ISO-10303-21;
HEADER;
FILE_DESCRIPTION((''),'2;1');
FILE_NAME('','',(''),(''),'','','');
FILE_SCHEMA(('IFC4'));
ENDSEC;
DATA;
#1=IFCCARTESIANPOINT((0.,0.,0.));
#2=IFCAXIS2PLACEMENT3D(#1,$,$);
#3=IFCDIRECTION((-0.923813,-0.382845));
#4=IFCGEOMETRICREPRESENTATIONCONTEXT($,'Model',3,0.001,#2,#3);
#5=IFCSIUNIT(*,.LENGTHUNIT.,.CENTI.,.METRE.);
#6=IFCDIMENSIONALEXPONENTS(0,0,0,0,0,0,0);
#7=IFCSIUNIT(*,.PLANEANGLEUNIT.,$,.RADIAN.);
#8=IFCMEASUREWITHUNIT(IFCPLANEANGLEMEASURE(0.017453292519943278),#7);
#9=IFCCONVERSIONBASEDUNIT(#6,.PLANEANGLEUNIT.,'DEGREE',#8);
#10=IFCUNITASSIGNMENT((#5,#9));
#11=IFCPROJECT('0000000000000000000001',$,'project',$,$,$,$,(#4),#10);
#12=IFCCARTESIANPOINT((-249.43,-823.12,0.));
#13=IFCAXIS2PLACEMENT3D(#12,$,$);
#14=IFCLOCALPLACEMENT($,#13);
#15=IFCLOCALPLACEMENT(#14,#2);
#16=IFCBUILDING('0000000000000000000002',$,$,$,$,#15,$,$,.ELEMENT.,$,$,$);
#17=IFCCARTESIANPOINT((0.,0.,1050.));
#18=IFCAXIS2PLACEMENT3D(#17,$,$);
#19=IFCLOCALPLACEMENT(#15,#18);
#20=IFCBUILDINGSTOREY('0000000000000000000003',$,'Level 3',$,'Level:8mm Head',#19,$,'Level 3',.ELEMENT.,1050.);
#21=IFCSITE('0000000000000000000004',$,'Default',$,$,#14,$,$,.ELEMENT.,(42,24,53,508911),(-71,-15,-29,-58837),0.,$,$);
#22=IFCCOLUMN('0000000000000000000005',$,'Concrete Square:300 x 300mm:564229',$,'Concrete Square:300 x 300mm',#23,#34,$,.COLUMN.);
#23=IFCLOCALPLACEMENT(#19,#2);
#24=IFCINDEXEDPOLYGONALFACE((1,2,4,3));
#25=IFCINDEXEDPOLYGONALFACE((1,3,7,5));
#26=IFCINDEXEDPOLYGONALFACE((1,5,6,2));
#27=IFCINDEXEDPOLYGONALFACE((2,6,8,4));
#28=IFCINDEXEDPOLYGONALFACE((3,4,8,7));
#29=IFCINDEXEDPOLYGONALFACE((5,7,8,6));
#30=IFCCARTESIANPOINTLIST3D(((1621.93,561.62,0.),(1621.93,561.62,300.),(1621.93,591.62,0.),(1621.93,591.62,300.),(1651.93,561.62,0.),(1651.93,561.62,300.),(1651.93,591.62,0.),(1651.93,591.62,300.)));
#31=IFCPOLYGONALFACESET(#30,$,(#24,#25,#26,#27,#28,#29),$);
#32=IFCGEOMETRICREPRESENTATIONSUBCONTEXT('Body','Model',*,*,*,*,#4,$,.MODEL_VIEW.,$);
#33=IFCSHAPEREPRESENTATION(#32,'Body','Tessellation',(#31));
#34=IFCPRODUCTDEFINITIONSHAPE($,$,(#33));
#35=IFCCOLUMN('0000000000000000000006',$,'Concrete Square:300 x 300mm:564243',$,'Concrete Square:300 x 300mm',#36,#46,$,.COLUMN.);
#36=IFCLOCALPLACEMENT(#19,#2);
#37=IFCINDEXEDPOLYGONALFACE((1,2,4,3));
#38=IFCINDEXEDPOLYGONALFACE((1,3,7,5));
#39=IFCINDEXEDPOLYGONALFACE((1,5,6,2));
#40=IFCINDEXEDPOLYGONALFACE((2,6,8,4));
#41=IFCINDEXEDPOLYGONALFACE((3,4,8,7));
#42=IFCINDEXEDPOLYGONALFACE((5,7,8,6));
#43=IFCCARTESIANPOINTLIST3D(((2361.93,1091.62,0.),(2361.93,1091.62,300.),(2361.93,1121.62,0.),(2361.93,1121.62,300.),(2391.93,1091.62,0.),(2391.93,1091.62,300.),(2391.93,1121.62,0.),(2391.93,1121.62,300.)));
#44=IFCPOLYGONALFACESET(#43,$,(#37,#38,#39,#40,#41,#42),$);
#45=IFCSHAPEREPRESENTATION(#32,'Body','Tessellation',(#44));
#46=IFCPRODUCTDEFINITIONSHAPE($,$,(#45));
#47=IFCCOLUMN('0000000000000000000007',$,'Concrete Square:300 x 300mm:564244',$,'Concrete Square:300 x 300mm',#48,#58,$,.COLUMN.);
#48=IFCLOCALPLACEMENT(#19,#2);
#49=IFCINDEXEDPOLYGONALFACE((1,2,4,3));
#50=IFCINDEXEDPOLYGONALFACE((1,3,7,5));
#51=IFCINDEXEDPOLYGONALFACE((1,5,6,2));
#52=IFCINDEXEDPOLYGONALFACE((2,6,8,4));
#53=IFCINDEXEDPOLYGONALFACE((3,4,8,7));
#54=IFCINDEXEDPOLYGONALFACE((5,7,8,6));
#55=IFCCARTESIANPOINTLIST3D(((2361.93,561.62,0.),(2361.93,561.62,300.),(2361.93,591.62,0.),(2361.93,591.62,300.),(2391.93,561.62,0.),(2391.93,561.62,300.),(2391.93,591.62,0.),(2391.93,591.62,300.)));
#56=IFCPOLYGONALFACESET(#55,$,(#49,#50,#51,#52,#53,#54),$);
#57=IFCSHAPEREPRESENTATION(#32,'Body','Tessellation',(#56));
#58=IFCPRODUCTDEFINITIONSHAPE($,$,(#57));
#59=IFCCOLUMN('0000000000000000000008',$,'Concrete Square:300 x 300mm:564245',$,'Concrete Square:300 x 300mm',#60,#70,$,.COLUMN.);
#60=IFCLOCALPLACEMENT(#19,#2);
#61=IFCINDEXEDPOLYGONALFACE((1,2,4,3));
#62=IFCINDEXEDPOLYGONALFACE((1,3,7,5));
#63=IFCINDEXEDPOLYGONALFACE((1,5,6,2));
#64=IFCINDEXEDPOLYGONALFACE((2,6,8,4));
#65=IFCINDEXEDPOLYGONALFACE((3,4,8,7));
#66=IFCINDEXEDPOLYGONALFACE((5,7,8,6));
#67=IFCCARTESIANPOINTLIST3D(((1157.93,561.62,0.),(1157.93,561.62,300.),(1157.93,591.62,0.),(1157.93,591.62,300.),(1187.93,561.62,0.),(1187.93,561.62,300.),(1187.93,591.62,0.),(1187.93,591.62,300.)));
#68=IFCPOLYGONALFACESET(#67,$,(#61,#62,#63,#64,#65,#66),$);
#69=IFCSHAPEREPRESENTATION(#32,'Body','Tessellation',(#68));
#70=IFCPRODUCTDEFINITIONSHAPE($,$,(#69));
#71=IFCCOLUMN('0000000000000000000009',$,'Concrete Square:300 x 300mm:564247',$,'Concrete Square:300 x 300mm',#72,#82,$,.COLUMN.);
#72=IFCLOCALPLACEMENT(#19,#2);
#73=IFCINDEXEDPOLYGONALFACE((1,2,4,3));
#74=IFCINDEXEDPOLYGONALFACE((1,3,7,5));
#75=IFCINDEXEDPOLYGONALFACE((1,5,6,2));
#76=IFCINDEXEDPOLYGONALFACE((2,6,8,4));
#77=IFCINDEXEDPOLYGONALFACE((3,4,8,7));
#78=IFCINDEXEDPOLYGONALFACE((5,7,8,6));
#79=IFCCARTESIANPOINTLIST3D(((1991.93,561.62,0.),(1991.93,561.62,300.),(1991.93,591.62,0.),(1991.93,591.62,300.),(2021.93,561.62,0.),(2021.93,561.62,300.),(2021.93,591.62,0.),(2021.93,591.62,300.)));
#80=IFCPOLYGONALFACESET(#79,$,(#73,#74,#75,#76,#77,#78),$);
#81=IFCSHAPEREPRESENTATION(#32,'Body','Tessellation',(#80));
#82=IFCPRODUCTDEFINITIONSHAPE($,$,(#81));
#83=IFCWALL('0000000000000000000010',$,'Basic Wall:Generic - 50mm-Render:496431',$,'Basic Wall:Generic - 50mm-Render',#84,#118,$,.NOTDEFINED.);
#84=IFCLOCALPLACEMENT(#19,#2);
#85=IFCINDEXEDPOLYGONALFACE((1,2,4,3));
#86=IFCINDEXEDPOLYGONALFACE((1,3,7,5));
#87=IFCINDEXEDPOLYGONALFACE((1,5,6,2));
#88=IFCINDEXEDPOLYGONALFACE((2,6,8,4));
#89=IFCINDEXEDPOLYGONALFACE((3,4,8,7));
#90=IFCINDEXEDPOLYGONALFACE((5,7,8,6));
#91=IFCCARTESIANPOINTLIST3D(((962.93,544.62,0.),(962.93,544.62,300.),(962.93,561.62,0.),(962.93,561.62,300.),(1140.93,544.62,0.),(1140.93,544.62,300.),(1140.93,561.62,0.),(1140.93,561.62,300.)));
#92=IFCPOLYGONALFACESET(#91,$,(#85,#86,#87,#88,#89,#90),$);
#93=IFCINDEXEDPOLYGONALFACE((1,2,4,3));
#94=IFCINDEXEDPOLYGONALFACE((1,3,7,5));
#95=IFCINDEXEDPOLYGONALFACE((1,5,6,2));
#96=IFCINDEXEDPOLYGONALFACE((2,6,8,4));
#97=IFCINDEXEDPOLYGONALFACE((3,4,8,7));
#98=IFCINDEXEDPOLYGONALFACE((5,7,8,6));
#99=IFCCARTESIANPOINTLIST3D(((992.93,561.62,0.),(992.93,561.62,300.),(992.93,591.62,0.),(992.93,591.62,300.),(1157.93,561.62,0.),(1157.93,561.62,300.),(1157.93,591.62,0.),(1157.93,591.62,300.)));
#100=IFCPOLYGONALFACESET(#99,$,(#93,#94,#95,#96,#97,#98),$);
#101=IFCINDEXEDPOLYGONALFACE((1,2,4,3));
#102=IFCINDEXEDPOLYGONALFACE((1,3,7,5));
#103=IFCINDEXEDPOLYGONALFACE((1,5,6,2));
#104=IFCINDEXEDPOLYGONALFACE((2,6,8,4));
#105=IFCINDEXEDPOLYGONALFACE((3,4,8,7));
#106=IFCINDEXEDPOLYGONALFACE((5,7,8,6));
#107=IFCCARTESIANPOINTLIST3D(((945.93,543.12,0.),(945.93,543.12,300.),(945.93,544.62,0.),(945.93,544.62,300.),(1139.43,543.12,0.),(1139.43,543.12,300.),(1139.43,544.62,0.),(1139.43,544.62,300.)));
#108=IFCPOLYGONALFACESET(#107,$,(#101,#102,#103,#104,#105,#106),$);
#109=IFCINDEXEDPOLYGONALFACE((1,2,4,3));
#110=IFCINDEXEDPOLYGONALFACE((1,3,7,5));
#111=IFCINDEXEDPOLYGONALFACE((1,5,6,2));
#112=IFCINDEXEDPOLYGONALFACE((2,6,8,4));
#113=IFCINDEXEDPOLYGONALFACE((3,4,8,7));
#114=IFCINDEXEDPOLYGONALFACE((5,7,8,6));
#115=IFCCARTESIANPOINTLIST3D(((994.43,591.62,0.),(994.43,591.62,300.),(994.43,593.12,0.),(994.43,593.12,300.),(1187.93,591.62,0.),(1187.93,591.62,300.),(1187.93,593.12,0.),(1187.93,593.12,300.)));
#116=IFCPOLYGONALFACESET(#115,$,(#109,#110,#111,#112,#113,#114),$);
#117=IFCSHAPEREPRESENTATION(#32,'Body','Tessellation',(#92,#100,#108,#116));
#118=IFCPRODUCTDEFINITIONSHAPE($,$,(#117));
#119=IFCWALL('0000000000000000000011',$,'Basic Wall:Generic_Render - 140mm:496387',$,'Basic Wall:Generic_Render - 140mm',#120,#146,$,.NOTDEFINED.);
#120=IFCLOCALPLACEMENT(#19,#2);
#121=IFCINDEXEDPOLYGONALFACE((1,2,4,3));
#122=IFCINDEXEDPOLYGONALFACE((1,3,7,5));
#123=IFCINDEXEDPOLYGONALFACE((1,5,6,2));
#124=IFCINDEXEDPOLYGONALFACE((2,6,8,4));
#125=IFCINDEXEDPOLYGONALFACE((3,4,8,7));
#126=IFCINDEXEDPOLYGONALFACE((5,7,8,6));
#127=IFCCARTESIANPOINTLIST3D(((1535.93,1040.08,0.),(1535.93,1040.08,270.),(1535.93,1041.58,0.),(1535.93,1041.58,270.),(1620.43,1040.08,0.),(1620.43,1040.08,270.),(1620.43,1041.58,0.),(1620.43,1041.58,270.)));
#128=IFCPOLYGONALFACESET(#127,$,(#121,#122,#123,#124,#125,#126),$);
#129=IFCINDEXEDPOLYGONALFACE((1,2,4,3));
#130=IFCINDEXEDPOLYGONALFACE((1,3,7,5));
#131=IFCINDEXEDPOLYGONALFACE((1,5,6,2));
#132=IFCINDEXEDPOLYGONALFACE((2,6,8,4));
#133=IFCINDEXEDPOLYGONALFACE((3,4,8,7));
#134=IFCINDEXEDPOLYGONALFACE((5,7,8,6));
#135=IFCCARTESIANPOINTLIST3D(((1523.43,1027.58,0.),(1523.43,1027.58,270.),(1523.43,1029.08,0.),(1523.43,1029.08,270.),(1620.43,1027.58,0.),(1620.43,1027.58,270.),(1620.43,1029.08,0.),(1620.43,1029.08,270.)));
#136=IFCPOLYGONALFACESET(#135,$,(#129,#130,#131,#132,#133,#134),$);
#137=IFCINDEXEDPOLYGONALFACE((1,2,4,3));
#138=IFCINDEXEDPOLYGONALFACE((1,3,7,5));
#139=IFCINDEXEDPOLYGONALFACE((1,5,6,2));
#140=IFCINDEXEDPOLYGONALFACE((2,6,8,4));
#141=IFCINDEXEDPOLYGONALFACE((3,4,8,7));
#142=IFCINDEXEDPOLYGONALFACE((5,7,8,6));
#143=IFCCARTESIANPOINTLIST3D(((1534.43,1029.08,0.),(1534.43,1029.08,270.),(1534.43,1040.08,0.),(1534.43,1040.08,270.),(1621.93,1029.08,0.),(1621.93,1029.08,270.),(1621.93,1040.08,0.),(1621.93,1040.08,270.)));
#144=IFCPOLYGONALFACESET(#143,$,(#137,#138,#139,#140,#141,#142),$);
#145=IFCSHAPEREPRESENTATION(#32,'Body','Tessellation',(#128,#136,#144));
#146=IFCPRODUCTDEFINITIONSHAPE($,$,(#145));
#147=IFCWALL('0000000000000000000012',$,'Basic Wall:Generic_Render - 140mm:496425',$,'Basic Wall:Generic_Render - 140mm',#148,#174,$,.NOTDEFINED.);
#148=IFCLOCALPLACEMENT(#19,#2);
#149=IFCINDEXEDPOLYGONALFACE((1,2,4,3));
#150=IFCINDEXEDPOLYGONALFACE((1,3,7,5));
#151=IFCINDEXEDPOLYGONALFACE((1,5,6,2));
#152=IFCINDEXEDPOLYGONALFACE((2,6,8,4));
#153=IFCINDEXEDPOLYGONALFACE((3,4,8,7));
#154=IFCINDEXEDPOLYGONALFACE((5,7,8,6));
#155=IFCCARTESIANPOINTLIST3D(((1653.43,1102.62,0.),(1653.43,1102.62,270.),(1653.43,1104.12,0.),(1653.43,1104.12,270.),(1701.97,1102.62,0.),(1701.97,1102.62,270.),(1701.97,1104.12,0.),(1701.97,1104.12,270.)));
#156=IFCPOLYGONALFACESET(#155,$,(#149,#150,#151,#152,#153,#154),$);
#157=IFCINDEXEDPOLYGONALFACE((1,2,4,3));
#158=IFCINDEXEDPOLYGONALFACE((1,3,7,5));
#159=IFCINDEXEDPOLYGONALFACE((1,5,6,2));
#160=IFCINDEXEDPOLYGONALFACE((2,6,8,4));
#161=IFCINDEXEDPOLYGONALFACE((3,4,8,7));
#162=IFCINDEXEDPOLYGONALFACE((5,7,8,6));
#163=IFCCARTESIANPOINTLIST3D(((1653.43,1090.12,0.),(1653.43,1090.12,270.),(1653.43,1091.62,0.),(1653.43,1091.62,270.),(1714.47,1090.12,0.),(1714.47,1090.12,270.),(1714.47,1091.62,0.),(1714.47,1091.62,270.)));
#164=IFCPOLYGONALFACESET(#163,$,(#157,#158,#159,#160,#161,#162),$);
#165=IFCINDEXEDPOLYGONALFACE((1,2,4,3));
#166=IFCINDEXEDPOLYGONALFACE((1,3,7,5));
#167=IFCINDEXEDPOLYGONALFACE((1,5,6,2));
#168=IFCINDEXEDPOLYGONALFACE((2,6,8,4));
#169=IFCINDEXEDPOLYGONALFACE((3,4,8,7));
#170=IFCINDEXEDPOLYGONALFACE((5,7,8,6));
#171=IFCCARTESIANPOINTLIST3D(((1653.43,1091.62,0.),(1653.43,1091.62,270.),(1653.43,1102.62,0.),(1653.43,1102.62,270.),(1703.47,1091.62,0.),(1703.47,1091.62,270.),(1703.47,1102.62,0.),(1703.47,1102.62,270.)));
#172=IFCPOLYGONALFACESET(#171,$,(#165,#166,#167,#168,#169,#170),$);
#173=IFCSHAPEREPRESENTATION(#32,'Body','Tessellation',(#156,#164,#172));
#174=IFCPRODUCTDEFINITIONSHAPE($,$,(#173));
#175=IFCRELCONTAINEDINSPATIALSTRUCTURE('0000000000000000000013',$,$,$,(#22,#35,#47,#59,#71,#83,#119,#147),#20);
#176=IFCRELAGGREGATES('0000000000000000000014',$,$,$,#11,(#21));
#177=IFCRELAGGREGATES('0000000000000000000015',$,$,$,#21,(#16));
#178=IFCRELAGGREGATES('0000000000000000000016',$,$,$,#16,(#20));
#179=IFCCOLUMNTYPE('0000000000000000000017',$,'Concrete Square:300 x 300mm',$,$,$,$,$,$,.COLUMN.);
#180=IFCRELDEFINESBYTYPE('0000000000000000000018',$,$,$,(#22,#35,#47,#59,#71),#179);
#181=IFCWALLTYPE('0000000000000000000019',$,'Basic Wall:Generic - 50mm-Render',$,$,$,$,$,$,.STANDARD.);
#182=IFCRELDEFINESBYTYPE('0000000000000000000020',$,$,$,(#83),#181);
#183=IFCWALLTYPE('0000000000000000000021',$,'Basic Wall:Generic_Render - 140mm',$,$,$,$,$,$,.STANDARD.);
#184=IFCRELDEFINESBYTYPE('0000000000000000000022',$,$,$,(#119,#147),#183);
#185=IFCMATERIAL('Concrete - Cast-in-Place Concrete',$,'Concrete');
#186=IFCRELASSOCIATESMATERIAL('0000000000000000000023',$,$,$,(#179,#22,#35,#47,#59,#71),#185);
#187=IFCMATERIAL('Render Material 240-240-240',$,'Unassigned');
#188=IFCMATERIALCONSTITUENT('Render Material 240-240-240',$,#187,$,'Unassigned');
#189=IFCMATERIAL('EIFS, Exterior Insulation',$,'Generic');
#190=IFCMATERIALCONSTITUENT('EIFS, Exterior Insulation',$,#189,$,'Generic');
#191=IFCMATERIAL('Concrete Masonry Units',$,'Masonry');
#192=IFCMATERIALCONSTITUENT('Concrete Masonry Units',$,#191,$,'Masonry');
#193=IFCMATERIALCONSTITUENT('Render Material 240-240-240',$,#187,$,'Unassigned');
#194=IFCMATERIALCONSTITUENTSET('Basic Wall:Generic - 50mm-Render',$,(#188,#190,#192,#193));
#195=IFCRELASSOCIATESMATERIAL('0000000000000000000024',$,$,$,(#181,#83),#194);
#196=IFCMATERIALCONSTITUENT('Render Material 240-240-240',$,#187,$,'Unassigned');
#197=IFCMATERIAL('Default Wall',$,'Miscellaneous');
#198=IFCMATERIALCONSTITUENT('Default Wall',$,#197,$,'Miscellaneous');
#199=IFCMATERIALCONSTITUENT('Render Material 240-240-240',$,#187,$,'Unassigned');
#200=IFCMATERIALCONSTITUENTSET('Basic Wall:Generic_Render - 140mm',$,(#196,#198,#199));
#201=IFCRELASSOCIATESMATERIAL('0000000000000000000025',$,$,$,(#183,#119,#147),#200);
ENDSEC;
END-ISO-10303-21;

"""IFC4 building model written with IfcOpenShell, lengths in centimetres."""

from ifc_helpers import new_model, entity, si_unit, converted_unit, direction, frame, origin, place, context, subcontext, project, spatial, indexed_curve, outline, extrude, source, transform, mapped, material, constituent, constituent_set, type_object, type_shapes, element, save


model = new_model("IFC4")

# Units and contexts
model_context = context("Model", 3, precision=0.001, world=origin(), true_north=direction((-0.923813, -0.382845)))
body_context = subcontext(model_context, "Body", "Model", "MODEL_VIEW")
ifc_project = project(units=[si_unit("LENGTHUNIT", "METRE", prefix="CENTI"), converted_unit("PLANEANGLEUNIT", "DEGREE", entity("IfcPlaneAngleMeasure", 0.017453292519943278), si_unit("PLANEANGLEUNIT", "RADIAN"), dimensions=[0, 0, 0, 0, 0, 0, 0])], contexts=[model_context])

# Site, building, storey
site_placement = place(None, frame((-249.43, -823.12, 0.0)))
site = spatial("IfcSite", under=ifc_project, at=site_placement, Name="Default", CompositionType="ELEMENT", RefLatitude=(42, 24, 53, 508911), RefLongitude=(-71, -15, -29, -58837), RefElevation=0.0)
building_placement = place(site_placement, origin())
building = spatial("IfcBuilding", under=site, at=building_placement, CompositionType="ELEMENT")
storey_placement = place(building_placement, frame((0.0, 0.0, 1050.0)))
storey = spatial("IfcBuildingStorey", under=building, at=storey_placement, Name="Level 3", ObjectType="Level:8mm Head", LongName="Level 3", CompositionType="ELEMENT", Elevation=1050.0)

# Columns
ifc_material_1 = material(Name="Concrete - Cast-in-Place Concrete", Category="Concrete")
column_type = type_object("IfcColumnType", Name="Concrete Square:300 x 300mm", PredefinedType="COLUMN", material=ifc_material_1)
shared_shape_1 = source(origin(), body_context, "Body", "SweptSolid", [
    extrude(outline(indexed_curve([(-15.0, -15.0), (15.0, -15.0), (15.0, 15.0), (-15.0, 15.0), (-15.0, -15.0)], self_intersect=False)), frame((0.0, 0.0, 1050.0), z_axis=(0.0, 0.0, 1.0), x_axis=(-1.0, 0.0, 0.0)), (0.0, 0.0, 1.0), 300.0),
])
type_shapes(column_type, [shared_shape_1])
for number, where, name in (
    (1, (1636.93, 576.62, -1050.0), "Concrete Square:300 x 300mm:564229"),
    (2, (2376.93, 1106.62, -1050.0), "Concrete Square:300 x 300mm:564243"),
    (3, (2376.93, 576.62, -1050.0), "Concrete Square:300 x 300mm:564244"),
    (4, (1172.93, 576.62, -1050.0), "Concrete Square:300 x 300mm:564245"),
    (5, (2006.93, 576.62, -1050.0), "Concrete Square:300 x 300mm:564247"),
):
    element("IfcColumn", number, at=place(storey_placement, frame(where)), inside=storey, type_object=column_type, material=ifc_material_1, Name=name, ObjectType="Concrete Square:300 x 300mm", PredefinedType="COLUMN", context=body_context, shape_type="MappedRepresentation", body=[
        mapped(shared_shape_1, transform((0.0, 0.0, 0.0), scale=1.0)),
    ])

# Walls
ifc_material_2 = material(Name="Render Material 240-240-240", Category="Unassigned")
ifc_material_3 = material(Name="Default Wall", Category="Miscellaneous")
ifc_constituent_1 = constituent(ifc_material_2, Name="Render Material 240-240-240", Category="Unassigned")
ifc_material_4 = material(Name="EIFS, Exterior Insulation", Category="Generic")
ifc_constituent_2 = constituent(ifc_material_4, Name="EIFS, Exterior Insulation", Category="Generic")
ifc_material_5 = material(Name="Concrete Masonry Units", Category="Masonry")
ifc_constituent_3 = constituent(ifc_material_5, Name="Concrete Masonry Units", Category="Masonry")
ifc_constituent_4 = constituent(ifc_material_2, Name="Render Material 240-240-240", Category="Unassigned")
ifc_constituent_set_1 = constituent_set(constituents=[ifc_constituent_1, ifc_constituent_2, ifc_constituent_3, ifc_constituent_4], Name="Basic Wall:Generic - 50mm-Render")
wall_type_1 = type_object("IfcWallType", Name="Basic Wall:Generic - 50mm-Render", PredefinedType="STANDARD", material=ifc_constituent_set_1)
wall_1_placement = place(storey_placement, frame((1139.43, 568.12, 0.0), z_axis=(0.0, 0.0, 1.0), x_axis=(-1.0, 0.0, 0.0)))
element("IfcWall", 6, at=wall_1_placement, inside=storey, type_object=wall_type_1, material=ifc_constituent_set_1, Name="Basic Wall:Generic - 50mm-Render:496431", ObjectType="Basic Wall:Generic - 50mm-Render", PredefinedType="NOTDEFINED", context=body_context, shape_type="SweptSolid", body=[
    extrude(outline(indexed_curve([(-89.0, -8.5), (89.0, -8.5), (89.0, 8.5), (-89.0, 8.5), (-89.0, -8.5)], self_intersect=False)), frame((87.5, 15.0, 0.0)), (0.0, 0.0, 1.0), 300.0),
    extrude(outline(indexed_curve([(-82.5, -15.0), (82.5, -15.0), (82.5, 15.0), (-82.5, 15.0), (-82.5, -15.0)], self_intersect=False)), frame((64.0, -8.5, 0.0)), (0.0, 0.0, 1.0), 300.0),
    extrude(outline(indexed_curve([(-0.75, -96.75), (0.75, -96.75), (0.75, 96.75), (-0.75, 96.75), (-0.75, -96.75)], self_intersect=False)), frame((96.75, 24.25, 0.0), z_axis=(0.0, 0.0, 1.0), x_axis=(0.0, -1.0, 0.0)), (0.0, 0.0, 1.0), 300.0),
    extrude(outline(indexed_curve([(-0.75, -96.75), (0.75, -96.75), (0.75, 96.75), (-0.75, 96.75), (-0.75, -96.75)], self_intersect=False)), frame((48.25, -24.25, 0.0), z_axis=(0.0, 0.0, 1.0), x_axis=(0.0, 1.0, 0.0)), (0.0, 0.0, 1.0), 300.0),
])
ifc_constituent_5 = constituent(ifc_material_2, Name="Render Material 240-240-240", Category="Unassigned")
ifc_constituent_6 = constituent(ifc_material_3, Name="Default Wall", Category="Miscellaneous")
ifc_constituent_7 = constituent(ifc_material_2, Name="Render Material 240-240-240", Category="Unassigned")
ifc_constituent_set_2 = constituent_set(constituents=[ifc_constituent_5, ifc_constituent_6, ifc_constituent_7], Name="Basic Wall:Generic_Render - 140mm")
wall_type_2 = type_object("IfcWallType", Name="Basic Wall:Generic_Render - 140mm", PredefinedType="STANDARD", material=ifc_constituent_set_2)
wall_2_placement = place(storey_placement, frame((1535.93, 1034.58, 0.0)))
element("IfcWall", 7, at=wall_2_placement, inside=storey, type_object=wall_type_2, material=ifc_constituent_set_2, Name="Basic Wall:Generic_Render - 140mm:496387", ObjectType="Basic Wall:Generic_Render - 140mm", PredefinedType="NOTDEFINED", context=body_context, shape_type="SweptSolid", body=[
    extrude(outline(indexed_curve([(-0.75, -42.25), (0.75, -42.25), (0.75, 42.25), (-0.75, 42.25), (-0.75, -42.25)], self_intersect=False)), frame((42.25, 6.25, 0.0), z_axis=(0.0, 0.0, 1.0), x_axis=(0.0, -1.0, 0.0)), (0.0, 0.0, 1.0), 270.0),
    extrude(outline(indexed_curve([(-0.75, -48.5), (0.75, -48.5), (0.75, 48.5), (-0.75, 48.5), (-0.75, -48.5)], self_intersect=False)), frame((36.0, -6.25, 0.0), z_axis=(0.0, 0.0, 1.0), x_axis=(0.0, 1.0, 0.0)), (0.0, 0.0, 1.0), 270.0),
    extrude(outline(indexed_curve([(-43.75, -5.5), (43.75, -5.5), (43.75, 5.5), (-43.75, 5.5), (-43.75, -5.5)], self_intersect=False)), frame((42.25, 0.0, 0.0)), (0.0, 0.0, 1.0), 270.0),
])
wall_3_placement = place(storey_placement, frame((1701.97, 1097.12, 0.0), z_axis=(0.0, 0.0, 1.0), x_axis=(-1.0, 0.0, 0.0)))
element("IfcWall", 8, at=wall_3_placement, inside=storey, type_object=wall_type_2, material=ifc_constituent_set_2, Name="Basic Wall:Generic_Render - 140mm:496425", ObjectType="Basic Wall:Generic_Render - 140mm", PredefinedType="NOTDEFINED", context=body_context, shape_type="SweptSolid", body=[
    extrude(outline(indexed_curve([(-0.75, -24.27), (0.75, -24.27), (0.75, 24.27), (-0.75, 24.27), (-0.75, -24.27)], self_intersect=False)), frame((24.27, -6.25, 0.0), z_axis=(0.0, 0.0, 1.0), x_axis=(0.0, 1.0, 0.0)), (0.0, 0.0, 1.0), 270.0),
    extrude(outline(indexed_curve([(-0.75, -30.52), (0.75, -30.52), (0.75, 30.52), (-0.75, 30.52), (-0.75, -30.52)], self_intersect=False)), frame((18.02, 6.25, 0.0), z_axis=(0.0, 0.0, 1.0), x_axis=(0.0, -1.0, 0.0)), (0.0, 0.0, 1.0), 270.0),
    extrude(outline(indexed_curve([(-25.02, -5.5), (25.02, -5.5), (25.02, 5.5), (-25.02, 5.5), (-25.02, -5.5)], self_intersect=False)), frame((23.52, 0.0, 0.0)), (0.0, 0.0, 1.0), 270.0),
])

save(model, "model.ifc")
